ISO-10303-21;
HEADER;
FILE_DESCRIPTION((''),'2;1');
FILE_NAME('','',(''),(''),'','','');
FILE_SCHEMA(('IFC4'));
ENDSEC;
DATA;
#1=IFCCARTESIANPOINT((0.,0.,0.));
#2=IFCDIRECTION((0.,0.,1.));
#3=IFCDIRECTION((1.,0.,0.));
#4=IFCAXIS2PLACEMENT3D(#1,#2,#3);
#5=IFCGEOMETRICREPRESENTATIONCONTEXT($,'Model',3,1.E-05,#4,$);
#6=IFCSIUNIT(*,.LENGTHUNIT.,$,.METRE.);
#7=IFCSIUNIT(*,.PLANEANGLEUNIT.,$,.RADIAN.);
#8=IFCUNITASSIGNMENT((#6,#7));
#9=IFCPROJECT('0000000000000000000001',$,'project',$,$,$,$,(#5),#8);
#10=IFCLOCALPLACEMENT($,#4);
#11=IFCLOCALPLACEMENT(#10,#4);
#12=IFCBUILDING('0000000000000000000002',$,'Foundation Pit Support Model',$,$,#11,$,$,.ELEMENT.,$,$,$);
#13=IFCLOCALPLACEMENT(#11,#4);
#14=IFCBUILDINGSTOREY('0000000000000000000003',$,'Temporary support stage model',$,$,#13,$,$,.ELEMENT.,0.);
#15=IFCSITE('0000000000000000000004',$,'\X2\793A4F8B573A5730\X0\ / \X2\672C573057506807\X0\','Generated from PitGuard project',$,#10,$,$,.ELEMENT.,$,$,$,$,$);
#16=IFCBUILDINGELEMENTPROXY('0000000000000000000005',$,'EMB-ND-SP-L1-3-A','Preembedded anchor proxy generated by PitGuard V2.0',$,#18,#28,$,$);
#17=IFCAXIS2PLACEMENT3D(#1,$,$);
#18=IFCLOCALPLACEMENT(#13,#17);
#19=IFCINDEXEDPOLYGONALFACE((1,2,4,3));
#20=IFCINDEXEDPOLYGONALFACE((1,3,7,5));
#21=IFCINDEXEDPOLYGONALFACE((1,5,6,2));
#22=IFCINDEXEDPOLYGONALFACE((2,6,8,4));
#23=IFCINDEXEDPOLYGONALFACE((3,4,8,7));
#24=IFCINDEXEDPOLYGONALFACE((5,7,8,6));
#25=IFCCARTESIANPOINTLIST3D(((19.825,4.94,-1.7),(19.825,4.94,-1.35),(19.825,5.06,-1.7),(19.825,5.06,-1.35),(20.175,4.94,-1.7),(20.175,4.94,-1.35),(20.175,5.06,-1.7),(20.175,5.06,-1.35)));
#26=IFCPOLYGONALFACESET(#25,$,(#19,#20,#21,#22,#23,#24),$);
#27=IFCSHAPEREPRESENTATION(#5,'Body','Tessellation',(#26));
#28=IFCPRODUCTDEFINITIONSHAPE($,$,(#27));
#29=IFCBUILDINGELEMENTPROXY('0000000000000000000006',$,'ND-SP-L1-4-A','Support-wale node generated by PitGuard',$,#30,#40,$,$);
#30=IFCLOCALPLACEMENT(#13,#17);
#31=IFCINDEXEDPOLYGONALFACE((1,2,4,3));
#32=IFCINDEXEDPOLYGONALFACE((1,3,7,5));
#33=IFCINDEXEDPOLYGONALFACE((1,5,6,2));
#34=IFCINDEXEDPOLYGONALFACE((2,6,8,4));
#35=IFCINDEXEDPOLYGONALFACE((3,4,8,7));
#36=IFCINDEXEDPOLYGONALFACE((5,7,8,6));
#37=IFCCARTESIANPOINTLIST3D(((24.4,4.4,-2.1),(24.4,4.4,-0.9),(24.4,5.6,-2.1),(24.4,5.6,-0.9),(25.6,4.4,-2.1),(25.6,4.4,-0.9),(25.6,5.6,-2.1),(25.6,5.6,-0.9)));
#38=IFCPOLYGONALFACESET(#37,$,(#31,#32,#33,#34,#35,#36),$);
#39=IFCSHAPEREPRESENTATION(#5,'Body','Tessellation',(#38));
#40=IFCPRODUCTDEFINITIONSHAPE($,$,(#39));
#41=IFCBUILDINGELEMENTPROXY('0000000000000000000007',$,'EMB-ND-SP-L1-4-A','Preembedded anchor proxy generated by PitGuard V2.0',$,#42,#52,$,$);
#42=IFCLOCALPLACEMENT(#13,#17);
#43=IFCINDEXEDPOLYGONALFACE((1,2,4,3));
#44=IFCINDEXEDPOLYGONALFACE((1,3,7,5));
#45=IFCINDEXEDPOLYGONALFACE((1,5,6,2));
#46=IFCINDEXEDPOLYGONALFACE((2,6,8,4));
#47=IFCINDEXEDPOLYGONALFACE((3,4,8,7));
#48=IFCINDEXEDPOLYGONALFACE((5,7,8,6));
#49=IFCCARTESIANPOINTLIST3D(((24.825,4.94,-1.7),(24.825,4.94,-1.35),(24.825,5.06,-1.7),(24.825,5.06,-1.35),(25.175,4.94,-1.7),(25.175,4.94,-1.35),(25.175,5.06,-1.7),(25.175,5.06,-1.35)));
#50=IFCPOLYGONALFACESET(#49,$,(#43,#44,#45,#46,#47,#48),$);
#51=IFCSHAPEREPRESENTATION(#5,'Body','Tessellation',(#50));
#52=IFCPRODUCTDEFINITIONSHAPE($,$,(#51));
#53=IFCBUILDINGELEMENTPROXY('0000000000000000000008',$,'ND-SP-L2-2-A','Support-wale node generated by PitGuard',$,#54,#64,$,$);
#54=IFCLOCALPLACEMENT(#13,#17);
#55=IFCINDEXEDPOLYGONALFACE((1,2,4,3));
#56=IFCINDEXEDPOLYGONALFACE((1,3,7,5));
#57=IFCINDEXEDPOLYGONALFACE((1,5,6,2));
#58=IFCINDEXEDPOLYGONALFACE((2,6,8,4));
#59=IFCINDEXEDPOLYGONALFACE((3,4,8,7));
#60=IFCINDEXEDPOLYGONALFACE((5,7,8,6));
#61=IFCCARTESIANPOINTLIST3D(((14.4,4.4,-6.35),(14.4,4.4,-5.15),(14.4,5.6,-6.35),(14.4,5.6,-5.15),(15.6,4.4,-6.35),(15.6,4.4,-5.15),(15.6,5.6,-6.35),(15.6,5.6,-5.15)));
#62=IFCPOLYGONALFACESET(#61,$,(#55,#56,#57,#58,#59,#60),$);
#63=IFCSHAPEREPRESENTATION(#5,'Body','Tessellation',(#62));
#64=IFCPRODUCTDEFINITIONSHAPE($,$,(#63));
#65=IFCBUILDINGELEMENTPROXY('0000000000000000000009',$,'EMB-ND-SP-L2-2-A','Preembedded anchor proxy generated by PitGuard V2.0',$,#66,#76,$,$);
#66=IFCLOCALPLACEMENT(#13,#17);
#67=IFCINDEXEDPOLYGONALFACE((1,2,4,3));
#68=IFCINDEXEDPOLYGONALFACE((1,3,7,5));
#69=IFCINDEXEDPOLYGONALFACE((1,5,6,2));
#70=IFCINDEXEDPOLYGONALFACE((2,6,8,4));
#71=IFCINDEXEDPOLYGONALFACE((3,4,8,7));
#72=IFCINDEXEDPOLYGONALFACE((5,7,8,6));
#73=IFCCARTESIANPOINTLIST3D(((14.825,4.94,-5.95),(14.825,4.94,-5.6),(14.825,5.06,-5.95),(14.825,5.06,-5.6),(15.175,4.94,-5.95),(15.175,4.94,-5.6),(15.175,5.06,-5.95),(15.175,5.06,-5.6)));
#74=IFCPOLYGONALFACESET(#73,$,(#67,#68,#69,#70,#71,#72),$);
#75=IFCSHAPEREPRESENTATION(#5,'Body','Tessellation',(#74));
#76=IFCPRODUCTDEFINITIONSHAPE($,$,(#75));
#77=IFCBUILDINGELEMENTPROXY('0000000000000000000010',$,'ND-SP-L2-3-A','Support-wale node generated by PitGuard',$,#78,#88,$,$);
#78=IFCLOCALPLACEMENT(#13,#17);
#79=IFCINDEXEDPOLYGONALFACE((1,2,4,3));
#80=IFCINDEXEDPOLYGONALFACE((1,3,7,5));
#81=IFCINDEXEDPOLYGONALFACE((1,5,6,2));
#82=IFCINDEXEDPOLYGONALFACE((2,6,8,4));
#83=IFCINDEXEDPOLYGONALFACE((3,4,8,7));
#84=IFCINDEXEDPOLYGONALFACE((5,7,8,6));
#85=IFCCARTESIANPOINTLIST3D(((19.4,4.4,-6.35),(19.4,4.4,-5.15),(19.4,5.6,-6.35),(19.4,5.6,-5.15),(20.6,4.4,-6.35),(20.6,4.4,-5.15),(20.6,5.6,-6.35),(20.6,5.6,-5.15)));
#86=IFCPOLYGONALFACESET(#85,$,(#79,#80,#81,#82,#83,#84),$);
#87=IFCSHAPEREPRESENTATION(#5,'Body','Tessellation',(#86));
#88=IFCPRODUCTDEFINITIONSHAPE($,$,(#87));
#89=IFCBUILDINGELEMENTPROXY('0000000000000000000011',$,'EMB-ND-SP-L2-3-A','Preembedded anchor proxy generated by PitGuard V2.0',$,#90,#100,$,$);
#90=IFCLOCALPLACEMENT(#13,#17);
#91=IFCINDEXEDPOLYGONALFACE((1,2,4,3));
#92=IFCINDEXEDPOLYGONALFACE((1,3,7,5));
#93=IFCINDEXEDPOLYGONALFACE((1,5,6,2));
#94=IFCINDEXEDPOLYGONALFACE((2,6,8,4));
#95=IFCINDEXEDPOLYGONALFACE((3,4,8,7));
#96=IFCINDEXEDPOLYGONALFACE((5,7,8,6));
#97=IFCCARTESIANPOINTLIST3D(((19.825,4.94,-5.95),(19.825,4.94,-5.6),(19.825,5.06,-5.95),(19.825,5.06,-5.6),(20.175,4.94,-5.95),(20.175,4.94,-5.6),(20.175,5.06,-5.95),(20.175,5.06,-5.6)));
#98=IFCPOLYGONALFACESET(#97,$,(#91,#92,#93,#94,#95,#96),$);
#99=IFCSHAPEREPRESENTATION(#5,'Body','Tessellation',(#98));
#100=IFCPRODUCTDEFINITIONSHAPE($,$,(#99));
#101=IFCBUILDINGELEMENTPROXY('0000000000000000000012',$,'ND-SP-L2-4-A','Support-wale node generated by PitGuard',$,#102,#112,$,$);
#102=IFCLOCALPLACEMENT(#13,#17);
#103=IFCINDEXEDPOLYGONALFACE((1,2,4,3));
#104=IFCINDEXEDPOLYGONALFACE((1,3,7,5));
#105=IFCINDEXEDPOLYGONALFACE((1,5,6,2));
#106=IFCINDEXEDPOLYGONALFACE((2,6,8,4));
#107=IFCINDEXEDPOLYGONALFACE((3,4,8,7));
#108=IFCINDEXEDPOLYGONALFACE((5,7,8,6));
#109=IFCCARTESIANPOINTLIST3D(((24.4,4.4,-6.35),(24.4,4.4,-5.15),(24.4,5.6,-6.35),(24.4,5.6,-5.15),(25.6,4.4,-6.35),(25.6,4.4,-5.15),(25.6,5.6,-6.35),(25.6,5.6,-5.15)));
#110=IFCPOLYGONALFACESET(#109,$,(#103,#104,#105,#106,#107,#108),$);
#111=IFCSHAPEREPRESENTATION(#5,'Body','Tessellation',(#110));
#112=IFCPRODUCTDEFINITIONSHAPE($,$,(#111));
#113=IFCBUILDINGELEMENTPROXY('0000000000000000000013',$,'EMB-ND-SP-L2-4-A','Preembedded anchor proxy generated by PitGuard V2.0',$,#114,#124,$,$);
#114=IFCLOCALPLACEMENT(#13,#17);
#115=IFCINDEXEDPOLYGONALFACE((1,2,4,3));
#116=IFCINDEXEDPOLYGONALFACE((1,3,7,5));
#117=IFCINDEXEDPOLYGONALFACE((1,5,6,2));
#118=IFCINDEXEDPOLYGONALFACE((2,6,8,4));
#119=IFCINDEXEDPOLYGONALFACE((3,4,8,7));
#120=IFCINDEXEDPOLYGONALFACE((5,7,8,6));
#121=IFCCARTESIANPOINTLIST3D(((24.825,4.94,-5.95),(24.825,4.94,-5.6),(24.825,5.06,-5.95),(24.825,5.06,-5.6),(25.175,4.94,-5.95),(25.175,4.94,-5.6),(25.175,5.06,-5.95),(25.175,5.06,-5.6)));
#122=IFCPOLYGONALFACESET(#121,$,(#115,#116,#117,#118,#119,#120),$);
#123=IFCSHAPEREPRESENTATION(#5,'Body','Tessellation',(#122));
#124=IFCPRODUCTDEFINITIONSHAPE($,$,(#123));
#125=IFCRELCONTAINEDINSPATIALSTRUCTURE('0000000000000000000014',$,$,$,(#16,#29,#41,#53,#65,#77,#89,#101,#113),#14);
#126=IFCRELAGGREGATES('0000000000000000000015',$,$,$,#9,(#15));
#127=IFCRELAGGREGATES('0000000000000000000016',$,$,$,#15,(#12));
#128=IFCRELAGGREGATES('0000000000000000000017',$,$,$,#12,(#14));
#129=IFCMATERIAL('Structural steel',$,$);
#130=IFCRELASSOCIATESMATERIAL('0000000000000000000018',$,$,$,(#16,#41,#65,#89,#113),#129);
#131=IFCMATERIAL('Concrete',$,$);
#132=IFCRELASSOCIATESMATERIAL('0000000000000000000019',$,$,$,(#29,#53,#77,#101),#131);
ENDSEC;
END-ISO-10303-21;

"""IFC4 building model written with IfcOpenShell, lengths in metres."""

from ifc_helpers import new_model, si_unit, frame, origin_with_axes, origin_2d, place, context, project, spatial, rectangle, extrude, material, element, save


model = new_model("IFC4")

# Units and contexts
model_context = context("Model", 3, precision=1e-05, world=origin_with_axes())
ifc_project = project(units=[si_unit("LENGTHUNIT", "METRE"), si_unit("PLANEANGLEUNIT", "RADIAN")], contexts=[model_context])

# Site, building, storey
site_placement = place(None, origin_with_axes())
site = spatial("IfcSite", under=ifc_project, at=site_placement, Name="示例场地 / 本地坐标", Description="Generated from PitGuard project", CompositionType="ELEMENT")
building_placement = place(site_placement, origin_with_axes())
building = spatial("IfcBuilding", under=site, at=building_placement, Name="Foundation Pit Support Model", CompositionType="ELEMENT")
storey_placement = place(building_placement, origin_with_axes())
storey = spatial("IfcBuildingStorey", under=building, at=storey_placement, Name="Temporary support stage model", CompositionType="ELEMENT", Elevation=0.0)

# Shared definitions
ifc_material_1 = material(Name="Concrete")

# Shared definitions
ifc_material_2 = material(Name="Structural steel")

# Building element proxies
proxy_1_placement = place(storey_placement, frame((20.0, 5.0, -1.7), z_axis=(0.0, 0.0, 1.0), x_axis=(1.0, 0.0, 0.0)))
element("IfcBuildingElementProxy", 1, at=proxy_1_placement, inside=storey, material=ifc_material_2, Name="EMB-ND-SP-L1-3-A", Description="Preembedded anchor proxy generated by PitGuard V2.0", context=model_context, shape_type="SweptSolid", body=[
    extrude(rectangle(XDim=0.35, YDim=0.12, at=origin_2d()), origin_with_axes(), (0.0, 0.0, 1.0), 0.35),
])
proxy_2_placement = place(storey_placement, frame((25.0, 5.0, -2.1), z_axis=(0.0, 0.0, 1.0), x_axis=(1.0, 0.0, 0.0)))
element("IfcBuildingElementProxy", 2, at=proxy_2_placement, inside=storey, material=ifc_material_1, Name="ND-SP-L1-4-A", Description="Support-wale node generated by PitGuard", context=model_context, shape_type="SweptSolid", body=[
    extrude(rectangle(XDim=1.2, YDim=1.2, at=origin_2d()), origin_with_axes(), (0.0, 0.0, 1.0), 1.2),
])
proxy_3_placement = place(storey_placement, frame((25.0, 5.0, -1.7), z_axis=(0.0, 0.0, 1.0), x_axis=(1.0, 0.0, 0.0)))
element("IfcBuildingElementProxy", 3, at=proxy_3_placement, inside=storey, material=ifc_material_2, Name="EMB-ND-SP-L1-4-A", Description="Preembedded anchor proxy generated by PitGuard V2.0", context=model_context, shape_type="SweptSolid", body=[
    extrude(rectangle(XDim=0.35, YDim=0.12, at=origin_2d()), origin_with_axes(), (0.0, 0.0, 1.0), 0.35),
])
proxy_4_placement = place(storey_placement, frame((15.0, 5.0, -6.35), z_axis=(0.0, 0.0, 1.0), x_axis=(1.0, 0.0, 0.0)))
element("IfcBuildingElementProxy", 4, at=proxy_4_placement, inside=storey, material=ifc_material_1, Name="ND-SP-L2-2-A", Description="Support-wale node generated by PitGuard", context=model_context, shape_type="SweptSolid", body=[
    extrude(rectangle(XDim=1.2, YDim=1.2, at=origin_2d()), origin_with_axes(), (0.0, 0.0, 1.0), 1.2),
])
proxy_5_placement = place(storey_placement, frame((15.0, 5.0, -5.95), z_axis=(0.0, 0.0, 1.0), x_axis=(1.0, 0.0, 0.0)))
element("IfcBuildingElementProxy", 5, at=proxy_5_placement, inside=storey, material=ifc_material_2, Name="EMB-ND-SP-L2-2-A", Description="Preembedded anchor proxy generated by PitGuard V2.0", context=model_context, shape_type="SweptSolid", body=[
    extrude(rectangle(XDim=0.35, YDim=0.12, at=origin_2d()), origin_with_axes(), (0.0, 0.0, 1.0), 0.35),
])
proxy_6_placement = place(storey_placement, frame((20.0, 5.0, -6.35), z_axis=(0.0, 0.0, 1.0), x_axis=(1.0, 0.0, 0.0)))
element("IfcBuildingElementProxy", 6, at=proxy_6_placement, inside=storey, material=ifc_material_1, Name="ND-SP-L2-3-A", Description="Support-wale node generated by PitGuard", context=model_context, shape_type="SweptSolid", body=[
    extrude(rectangle(XDim=1.2, YDim=1.2, at=origin_2d()), origin_with_axes(), (0.0, 0.0, 1.0), 1.2),
])
proxy_7_placement = place(storey_placement, frame((20.0, 5.0, -5.95), z_axis=(0.0, 0.0, 1.0), x_axis=(1.0, 0.0, 0.0)))
element("IfcBuildingElementProxy", 7, at=proxy_7_placement, inside=storey, material=ifc_material_2, Name="EMB-ND-SP-L2-3-A", Description="Preembedded anchor proxy generated by PitGuard V2.0", context=model_context, shape_type="SweptSolid", body=[
    extrude(rectangle(XDim=0.35, YDim=0.12, at=origin_2d()), origin_with_axes(), (0.0, 0.0, 1.0), 0.35),
])
proxy_8_placement = place(storey_placement, frame((25.0, 5.0, -6.35), z_axis=(0.0, 0.0, 1.0), x_axis=(1.0, 0.0, 0.0)))
element("IfcBuildingElementProxy", 8, at=proxy_8_placement, inside=storey, material=ifc_material_1, Name="ND-SP-L2-4-A", Description="Support-wale node generated by PitGuard", context=model_context, shape_type="SweptSolid", body=[
    extrude(rectangle(XDim=1.2, YDim=1.2, at=origin_2d()), origin_with_axes(), (0.0, 0.0, 1.0), 1.2),
])
proxy_9_placement = place(storey_placement, frame((25.0, 5.0, -5.95), z_axis=(0.0, 0.0, 1.0), x_axis=(1.0, 0.0, 0.0)))
element("IfcBuildingElementProxy", 9, at=proxy_9_placement, inside=storey, material=ifc_material_2, Name="EMB-ND-SP-L2-4-A", Description="Preembedded anchor proxy generated by PitGuard V2.0", context=model_context, shape_type="SweptSolid", body=[
    extrude(rectangle(XDim=0.35, YDim=0.12, at=origin_2d()), origin_with_axes(), (0.0, 0.0, 1.0), 0.35),
])

save(model, "model.ifc")
